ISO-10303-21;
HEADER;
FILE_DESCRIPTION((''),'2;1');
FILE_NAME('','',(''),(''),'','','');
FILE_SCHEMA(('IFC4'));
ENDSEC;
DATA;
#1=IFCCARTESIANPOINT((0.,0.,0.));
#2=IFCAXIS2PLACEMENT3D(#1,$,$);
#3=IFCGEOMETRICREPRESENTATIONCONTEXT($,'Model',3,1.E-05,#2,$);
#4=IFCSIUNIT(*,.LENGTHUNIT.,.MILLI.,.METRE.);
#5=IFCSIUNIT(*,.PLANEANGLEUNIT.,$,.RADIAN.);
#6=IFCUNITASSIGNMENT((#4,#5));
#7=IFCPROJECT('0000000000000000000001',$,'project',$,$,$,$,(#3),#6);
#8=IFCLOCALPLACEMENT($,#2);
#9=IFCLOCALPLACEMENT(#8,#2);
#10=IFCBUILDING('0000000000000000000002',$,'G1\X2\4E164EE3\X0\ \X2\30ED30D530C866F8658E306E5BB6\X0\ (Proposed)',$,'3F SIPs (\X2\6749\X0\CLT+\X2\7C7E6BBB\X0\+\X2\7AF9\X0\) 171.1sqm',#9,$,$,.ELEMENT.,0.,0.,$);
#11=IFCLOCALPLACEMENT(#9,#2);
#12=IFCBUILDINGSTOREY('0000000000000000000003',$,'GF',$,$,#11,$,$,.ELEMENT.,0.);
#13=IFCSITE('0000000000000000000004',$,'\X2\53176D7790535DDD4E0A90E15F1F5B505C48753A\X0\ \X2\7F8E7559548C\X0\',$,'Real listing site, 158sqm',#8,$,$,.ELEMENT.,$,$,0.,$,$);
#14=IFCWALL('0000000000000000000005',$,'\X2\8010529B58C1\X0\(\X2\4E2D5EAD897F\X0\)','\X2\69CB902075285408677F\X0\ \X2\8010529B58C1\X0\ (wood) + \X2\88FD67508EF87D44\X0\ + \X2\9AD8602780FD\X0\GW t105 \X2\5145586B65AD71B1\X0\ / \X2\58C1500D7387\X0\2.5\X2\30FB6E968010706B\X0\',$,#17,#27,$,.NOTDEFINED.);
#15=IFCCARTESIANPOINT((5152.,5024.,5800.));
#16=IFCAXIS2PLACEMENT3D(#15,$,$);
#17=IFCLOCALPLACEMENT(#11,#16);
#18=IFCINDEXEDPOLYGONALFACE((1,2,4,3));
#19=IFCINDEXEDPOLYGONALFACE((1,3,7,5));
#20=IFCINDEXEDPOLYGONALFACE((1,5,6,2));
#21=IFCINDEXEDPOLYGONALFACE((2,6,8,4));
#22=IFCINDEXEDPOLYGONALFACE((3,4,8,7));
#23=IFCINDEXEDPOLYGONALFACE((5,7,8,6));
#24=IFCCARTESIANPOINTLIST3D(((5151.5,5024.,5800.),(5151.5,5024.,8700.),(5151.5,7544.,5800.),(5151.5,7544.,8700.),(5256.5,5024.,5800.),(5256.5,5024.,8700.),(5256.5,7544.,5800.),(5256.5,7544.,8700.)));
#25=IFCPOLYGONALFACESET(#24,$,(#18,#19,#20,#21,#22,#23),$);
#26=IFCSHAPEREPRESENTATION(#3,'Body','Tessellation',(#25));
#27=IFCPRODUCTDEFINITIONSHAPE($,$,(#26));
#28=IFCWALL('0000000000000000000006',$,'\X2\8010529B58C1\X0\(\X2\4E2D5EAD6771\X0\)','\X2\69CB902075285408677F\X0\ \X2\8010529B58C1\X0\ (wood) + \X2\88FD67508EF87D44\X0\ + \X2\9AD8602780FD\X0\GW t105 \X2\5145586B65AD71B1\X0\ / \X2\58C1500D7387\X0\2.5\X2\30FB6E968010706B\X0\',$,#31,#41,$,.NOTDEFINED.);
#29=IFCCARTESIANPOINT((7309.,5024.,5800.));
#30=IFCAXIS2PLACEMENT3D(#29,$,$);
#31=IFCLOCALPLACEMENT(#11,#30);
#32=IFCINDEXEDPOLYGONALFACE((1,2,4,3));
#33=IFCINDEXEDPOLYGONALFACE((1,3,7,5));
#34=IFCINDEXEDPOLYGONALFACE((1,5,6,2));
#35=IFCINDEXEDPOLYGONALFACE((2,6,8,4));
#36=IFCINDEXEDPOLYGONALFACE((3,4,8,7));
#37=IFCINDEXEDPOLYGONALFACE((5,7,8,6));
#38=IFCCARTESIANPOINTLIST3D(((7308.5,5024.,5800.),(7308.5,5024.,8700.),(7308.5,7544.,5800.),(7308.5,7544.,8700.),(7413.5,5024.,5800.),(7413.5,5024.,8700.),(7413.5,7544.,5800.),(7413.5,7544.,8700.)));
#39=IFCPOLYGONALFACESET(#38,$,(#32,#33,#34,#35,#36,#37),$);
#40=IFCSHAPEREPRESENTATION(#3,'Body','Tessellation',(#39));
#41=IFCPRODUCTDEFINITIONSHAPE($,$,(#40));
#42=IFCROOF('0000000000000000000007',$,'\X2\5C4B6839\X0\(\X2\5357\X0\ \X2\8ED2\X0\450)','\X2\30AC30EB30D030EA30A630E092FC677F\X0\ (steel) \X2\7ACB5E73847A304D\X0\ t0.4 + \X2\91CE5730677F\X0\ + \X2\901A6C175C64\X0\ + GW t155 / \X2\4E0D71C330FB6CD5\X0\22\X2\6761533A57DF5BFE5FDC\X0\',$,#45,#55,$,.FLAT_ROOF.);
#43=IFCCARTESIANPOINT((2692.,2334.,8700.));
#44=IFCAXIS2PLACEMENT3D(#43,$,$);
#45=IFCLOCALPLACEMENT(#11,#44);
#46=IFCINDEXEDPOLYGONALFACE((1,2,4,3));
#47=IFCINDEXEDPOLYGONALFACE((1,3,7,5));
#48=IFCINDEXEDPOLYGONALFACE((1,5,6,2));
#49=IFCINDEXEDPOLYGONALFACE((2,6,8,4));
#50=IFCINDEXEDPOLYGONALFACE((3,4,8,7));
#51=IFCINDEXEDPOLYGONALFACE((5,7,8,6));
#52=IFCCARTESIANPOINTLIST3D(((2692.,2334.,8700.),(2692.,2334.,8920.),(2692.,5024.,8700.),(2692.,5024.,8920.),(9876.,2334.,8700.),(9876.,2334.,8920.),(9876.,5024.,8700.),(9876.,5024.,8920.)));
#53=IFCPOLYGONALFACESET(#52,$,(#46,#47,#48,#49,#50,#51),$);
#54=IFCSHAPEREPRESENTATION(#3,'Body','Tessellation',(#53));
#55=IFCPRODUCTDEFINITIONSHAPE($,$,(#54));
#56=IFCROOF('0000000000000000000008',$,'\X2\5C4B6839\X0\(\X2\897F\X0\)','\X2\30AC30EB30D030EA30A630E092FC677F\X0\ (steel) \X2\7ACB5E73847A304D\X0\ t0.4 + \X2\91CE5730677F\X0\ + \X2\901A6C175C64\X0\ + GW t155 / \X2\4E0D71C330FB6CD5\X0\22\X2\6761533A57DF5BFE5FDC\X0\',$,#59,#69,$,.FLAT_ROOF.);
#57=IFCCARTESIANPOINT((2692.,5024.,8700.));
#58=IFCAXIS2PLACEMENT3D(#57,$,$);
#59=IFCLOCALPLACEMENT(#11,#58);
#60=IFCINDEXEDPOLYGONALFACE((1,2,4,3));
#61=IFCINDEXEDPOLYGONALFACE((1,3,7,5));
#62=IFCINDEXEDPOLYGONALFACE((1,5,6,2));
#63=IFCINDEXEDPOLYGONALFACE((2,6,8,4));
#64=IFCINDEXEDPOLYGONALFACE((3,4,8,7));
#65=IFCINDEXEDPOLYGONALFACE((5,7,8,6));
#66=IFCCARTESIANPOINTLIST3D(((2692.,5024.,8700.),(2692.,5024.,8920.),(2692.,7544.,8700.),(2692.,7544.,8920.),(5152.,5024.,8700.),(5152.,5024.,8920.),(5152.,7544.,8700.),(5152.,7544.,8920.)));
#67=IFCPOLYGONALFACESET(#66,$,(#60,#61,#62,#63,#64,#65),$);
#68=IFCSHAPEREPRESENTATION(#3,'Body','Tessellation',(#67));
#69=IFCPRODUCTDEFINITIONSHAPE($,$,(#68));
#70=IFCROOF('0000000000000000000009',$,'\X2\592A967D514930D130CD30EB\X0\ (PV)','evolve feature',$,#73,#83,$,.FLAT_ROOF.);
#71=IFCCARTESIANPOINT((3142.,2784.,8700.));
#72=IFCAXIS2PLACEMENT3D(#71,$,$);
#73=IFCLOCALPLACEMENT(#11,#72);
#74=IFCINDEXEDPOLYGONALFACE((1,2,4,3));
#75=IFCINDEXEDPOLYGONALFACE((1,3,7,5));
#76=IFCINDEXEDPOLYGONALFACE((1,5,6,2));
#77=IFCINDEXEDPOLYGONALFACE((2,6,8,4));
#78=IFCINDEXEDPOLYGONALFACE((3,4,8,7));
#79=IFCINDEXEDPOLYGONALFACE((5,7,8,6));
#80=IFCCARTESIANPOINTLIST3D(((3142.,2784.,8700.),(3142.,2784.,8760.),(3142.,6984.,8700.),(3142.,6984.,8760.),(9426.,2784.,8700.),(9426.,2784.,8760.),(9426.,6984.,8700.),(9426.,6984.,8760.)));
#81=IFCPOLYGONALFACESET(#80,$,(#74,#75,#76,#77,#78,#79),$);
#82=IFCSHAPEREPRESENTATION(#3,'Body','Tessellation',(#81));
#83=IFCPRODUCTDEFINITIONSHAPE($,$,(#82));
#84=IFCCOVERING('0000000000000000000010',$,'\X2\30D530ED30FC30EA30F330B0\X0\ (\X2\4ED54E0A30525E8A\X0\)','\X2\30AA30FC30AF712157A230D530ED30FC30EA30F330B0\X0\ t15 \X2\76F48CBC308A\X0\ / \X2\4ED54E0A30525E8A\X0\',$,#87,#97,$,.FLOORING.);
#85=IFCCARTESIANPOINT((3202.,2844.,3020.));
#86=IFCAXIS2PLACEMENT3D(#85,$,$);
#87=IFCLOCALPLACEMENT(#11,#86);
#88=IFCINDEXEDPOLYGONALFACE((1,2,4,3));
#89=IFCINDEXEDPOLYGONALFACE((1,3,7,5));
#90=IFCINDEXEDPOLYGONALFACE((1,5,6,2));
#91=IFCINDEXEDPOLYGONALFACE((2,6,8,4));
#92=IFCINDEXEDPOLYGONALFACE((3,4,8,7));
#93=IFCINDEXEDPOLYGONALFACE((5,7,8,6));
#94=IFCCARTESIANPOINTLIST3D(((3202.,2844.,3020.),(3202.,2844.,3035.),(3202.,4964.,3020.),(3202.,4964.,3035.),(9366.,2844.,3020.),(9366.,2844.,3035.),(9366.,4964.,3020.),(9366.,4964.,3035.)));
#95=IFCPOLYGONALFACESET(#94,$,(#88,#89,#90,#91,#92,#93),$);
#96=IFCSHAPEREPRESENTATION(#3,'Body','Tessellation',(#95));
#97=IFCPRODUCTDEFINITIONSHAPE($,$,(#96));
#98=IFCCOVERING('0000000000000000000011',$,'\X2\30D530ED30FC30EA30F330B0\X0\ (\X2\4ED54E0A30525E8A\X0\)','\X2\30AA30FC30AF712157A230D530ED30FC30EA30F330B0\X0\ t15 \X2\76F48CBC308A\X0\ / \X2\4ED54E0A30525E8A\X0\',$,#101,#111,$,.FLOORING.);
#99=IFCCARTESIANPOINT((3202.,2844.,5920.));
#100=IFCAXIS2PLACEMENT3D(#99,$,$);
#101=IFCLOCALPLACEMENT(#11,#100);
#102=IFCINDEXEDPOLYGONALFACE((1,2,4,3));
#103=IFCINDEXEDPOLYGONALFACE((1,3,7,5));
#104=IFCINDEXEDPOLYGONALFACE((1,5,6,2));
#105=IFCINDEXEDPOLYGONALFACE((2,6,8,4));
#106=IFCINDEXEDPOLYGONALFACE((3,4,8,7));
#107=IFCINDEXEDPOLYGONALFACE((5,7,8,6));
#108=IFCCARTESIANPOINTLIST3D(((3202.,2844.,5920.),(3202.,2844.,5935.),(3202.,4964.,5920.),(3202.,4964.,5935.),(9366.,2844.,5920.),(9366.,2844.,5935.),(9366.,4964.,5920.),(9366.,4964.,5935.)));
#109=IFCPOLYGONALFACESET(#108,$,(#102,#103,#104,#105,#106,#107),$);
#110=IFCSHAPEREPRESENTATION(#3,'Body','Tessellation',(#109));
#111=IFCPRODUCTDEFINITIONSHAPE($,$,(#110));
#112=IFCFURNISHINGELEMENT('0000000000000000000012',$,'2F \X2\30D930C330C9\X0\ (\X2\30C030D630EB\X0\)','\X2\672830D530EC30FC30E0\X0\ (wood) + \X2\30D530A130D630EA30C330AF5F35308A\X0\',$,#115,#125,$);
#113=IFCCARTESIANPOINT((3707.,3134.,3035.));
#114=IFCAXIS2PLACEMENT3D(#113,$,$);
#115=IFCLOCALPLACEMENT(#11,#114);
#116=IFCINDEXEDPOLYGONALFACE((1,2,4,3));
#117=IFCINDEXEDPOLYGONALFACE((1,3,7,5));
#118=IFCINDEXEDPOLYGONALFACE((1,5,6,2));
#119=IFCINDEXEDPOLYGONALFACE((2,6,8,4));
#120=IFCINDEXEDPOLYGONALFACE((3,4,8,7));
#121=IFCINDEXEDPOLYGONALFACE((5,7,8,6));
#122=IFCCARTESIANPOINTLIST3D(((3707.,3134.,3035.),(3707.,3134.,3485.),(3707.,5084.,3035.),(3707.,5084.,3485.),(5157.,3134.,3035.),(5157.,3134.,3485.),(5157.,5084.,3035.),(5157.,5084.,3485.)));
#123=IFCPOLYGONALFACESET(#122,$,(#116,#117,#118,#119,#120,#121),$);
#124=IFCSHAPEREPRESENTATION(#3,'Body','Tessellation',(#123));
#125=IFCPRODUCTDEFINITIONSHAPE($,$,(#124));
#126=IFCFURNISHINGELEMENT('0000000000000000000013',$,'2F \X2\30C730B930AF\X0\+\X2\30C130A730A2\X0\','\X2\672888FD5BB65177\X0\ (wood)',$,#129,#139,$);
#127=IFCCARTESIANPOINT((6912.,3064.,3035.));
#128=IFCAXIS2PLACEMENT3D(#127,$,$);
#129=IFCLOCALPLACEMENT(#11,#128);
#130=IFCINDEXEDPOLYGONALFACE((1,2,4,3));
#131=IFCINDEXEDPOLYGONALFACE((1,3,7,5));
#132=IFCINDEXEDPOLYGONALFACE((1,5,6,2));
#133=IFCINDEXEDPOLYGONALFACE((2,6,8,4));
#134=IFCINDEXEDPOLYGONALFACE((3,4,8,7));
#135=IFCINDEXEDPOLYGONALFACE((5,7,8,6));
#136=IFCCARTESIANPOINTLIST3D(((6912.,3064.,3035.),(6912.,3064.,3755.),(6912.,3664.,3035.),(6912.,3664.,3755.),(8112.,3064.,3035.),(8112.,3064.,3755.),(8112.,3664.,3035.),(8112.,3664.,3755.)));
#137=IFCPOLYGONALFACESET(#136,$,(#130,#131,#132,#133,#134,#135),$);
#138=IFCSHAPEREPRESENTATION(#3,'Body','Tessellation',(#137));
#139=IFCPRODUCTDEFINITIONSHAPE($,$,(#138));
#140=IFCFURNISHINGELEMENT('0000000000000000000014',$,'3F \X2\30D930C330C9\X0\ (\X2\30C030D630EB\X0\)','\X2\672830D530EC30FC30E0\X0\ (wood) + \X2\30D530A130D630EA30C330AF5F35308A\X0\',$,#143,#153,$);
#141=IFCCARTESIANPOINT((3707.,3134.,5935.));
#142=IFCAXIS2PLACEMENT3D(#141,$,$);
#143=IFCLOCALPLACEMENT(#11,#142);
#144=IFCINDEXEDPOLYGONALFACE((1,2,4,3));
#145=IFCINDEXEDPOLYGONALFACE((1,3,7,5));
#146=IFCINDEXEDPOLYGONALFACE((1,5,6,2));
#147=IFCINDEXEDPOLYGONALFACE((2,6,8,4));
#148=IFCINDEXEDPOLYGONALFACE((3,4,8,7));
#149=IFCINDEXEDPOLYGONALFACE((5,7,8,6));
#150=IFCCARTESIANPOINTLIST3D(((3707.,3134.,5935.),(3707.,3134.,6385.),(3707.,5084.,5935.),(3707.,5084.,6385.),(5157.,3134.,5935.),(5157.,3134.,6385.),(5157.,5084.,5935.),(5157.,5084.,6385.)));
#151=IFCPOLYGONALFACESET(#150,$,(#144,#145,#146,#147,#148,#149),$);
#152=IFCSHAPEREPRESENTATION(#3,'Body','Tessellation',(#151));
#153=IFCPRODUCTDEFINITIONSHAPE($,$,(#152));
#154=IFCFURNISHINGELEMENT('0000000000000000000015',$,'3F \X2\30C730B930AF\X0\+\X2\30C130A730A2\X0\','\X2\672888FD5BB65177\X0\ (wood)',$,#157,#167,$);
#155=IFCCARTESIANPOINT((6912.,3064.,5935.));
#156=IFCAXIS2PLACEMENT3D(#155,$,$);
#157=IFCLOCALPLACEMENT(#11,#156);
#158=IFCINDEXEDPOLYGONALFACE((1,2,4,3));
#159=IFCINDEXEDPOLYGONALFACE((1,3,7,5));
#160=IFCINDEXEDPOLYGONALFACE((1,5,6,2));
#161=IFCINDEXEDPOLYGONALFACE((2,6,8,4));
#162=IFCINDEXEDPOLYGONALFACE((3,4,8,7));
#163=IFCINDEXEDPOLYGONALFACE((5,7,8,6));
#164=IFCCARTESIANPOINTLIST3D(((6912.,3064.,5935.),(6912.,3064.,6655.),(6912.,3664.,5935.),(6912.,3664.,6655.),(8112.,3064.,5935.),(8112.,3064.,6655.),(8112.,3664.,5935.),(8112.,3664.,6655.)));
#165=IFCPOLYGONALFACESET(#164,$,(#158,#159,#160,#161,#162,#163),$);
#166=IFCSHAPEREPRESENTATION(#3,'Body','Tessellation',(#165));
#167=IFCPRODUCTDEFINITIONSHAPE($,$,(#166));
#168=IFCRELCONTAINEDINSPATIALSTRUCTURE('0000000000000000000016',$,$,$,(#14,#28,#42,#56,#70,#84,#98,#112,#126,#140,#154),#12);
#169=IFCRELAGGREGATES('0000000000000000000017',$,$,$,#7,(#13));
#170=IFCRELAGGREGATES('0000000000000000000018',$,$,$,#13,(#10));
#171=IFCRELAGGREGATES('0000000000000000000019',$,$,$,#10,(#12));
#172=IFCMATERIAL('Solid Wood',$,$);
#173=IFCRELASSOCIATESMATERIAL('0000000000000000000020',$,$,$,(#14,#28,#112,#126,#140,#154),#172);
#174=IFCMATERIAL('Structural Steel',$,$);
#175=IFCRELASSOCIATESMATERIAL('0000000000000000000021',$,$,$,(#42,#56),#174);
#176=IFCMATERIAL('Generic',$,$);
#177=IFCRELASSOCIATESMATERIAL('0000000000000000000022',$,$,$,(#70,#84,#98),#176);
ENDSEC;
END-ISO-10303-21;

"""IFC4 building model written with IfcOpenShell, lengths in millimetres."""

from ifc_helpers import new_model, si_unit, frame, frame_2d, origin, place, context, project, spatial, rectangle, extrude, material, element, save


model = new_model("IFC4")

# Units and contexts
model_context = context("Model", 3, precision=1e-05, world=origin())
ifc_project = project(units=[si_unit("LENGTHUNIT", "METRE", prefix="MILLI"), si_unit("PLANEANGLEUNIT", "RADIAN")], contexts=[model_context])

# Site, building, storey
site_placement = place(None, origin())
site = spatial("IfcSite", under=ifc_project, at=site_placement, Name="北海道川上郡弟子屈町 美留和", ObjectType="Real listing site, 158sqm", CompositionType="ELEMENT", RefElevation=0.0)
building_placement = place(site_placement, origin())
building = spatial("IfcBuilding", under=site, at=building_placement, Name="G1世代 ロフト書斎の家 (Proposed)", ObjectType="3F SIPs (杉CLT+籾殻+竹) 171.1sqm", CompositionType="ELEMENT", ElevationOfRefHeight=0.0, ElevationOfTerrain=0.0)
storey_placement = place(building_placement, origin())
storey = spatial("IfcBuildingStorey", under=building, at=storey_placement, Name="GF", CompositionType="ELEMENT", Elevation=0.0)

# Shared definitions
ifc_material_1 = material(Name="Solid Wood")

# Walls
wall_1_placement = place(storey_placement, frame((5152.0, 5024.0, 5800.0)))
element("IfcWall", 1, at=wall_1_placement, inside=storey, material=ifc_material_1, Name="耐力壁(中庭西)", Description="構造用合板 耐力壁 (wood) + 製材軸組 + 高性能GW t105 充填断熱 / 壁倍率2.5・準耐火", PredefinedType="NOTDEFINED", context=model_context, shape_type="SweptSolid", body=[
    extrude(rectangle(XDim=105.0, YDim=2520.0, at=frame_2d((52.0, 1260.0))), frame((5152.0, 5024.0, 5800.0)), (0.0, 0.0, 1.0), 2900.0),
])
wall_2_placement = place(storey_placement, frame((7309.0, 5024.0, 5800.0)))
element("IfcWall", 2, at=wall_2_placement, inside=storey, material=ifc_material_1, Name="耐力壁(中庭東)", Description="構造用合板 耐力壁 (wood) + 製材軸組 + 高性能GW t105 充填断熱 / 壁倍率2.5・準耐火", PredefinedType="NOTDEFINED", context=model_context, shape_type="SweptSolid", body=[
    extrude(rectangle(XDim=105.0, YDim=2520.0, at=frame_2d((52.0, 1260.0))), frame((7309.0, 5024.0, 5800.0)), (0.0, 0.0, 1.0), 2900.0),
])

# Roofs
ifc_material_2 = material(Name="Structural Steel")
roof_1_placement = place(storey_placement, frame((2692.0, 2334.0, 8700.0)))
element("IfcRoof", 3, at=roof_1_placement, inside=storey, material=ifc_material_2, Name="屋根(南 軒450)", Description="ガルバリウム鋼板 (steel) 立平葺き t0.4 + 野地板 + 通気層 + GW t155 / 不燃・法22条区域対応", PredefinedType="FLAT_ROOF", context=model_context, shape_type="SweptSolid", body=[
    extrude(rectangle(XDim=7184.0, YDim=2690.0, at=frame_2d((3592.0, 1345.0))), frame((2692.0, 2334.0, 8700.0)), (0.0, 0.0, 1.0), 220.0),
])
roof_2_placement = place(storey_placement, frame((2692.0, 5024.0, 8700.0)))
element("IfcRoof", 4, at=roof_2_placement, inside=storey, material=ifc_material_2, Name="屋根(西)", Description="ガルバリウム鋼板 (steel) 立平葺き t0.4 + 野地板 + 通気層 + GW t155 / 不燃・法22条区域対応", PredefinedType="FLAT_ROOF", context=model_context, shape_type="SweptSolid", body=[
    extrude(rectangle(XDim=2460.0, YDim=2520.0, at=frame_2d((1230.0, 1260.0))), frame((2692.0, 5024.0, 8700.0)), (0.0, 0.0, 1.0), 220.0),
])
ifc_material_3 = material(Name="Generic")
roof_3_placement = place(storey_placement, frame((3142.0, 2784.0, 8700.0)))
element("IfcRoof", 5, at=roof_3_placement, inside=storey, material=ifc_material_3, Name="太陽光パネル (PV)", Description="evolve feature", PredefinedType="FLAT_ROOF", context=model_context, shape_type="SweptSolid", body=[
    extrude(rectangle(XDim=6284.0, YDim=4200.0, at=frame_2d((3142.0, 2100.0))), frame((3142.0, 2784.0, 8700.0)), (0.0, 0.0, 1.0), 60.0),
])

# Coverings
covering_1_placement = place(storey_placement, frame((3202.0, 2844.0, 3020.0)))
element("IfcCovering", 6, at=covering_1_placement, inside=storey, material=ifc_material_3, Name="フローリング (仕上げ床)", Description="オーク無垢フローリング t15 直貼り / 仕上げ床", PredefinedType="FLOORING", context=model_context, shape_type="SweptSolid", body=[
    extrude(rectangle(XDim=6164.0, YDim=2120.0, at=frame_2d((3082.0, 1060.0))), frame((3202.0, 2844.0, 3020.0)), (0.0, 0.0, 1.0), 15.0),
])
covering_2_placement = place(storey_placement, frame((3202.0, 2844.0, 5920.0)))
element("IfcCovering", 7, at=covering_2_placement, inside=storey, material=ifc_material_3, Name="フローリング (仕上げ床)", Description="オーク無垢フローリング t15 直貼り / 仕上げ床", PredefinedType="FLOORING", context=model_context, shape_type="SweptSolid", body=[
    extrude(rectangle(XDim=6164.0, YDim=2120.0, at=frame_2d((3082.0, 1060.0))), frame((3202.0, 2844.0, 5920.0)), (0.0, 0.0, 1.0), 15.0),
])

# Furnishing elements
furnishing_1_placement = place(storey_placement, frame((3707.0, 3134.0, 3035.0)))
element("IfcFurnishingElement", 8, at=furnishing_1_placement, inside=storey, material=ifc_material_1, Name="2F ベッド (ダブル)", Description="木フレーム (wood) + ファブリック張り", context=model_context, shape_type="SweptSolid", body=[
    extrude(rectangle(XDim=1450.0, YDim=1950.0, at=frame_2d((725.0, 975.0))), frame((3707.0, 3134.0, 3035.0)), (0.0, 0.0, 1.0), 450.0),
])
furnishing_2_placement = place(storey_placement, frame((6912.0, 3064.0, 3035.0)))
element("IfcFurnishingElement", 9, at=furnishing_2_placement, inside=storey, material=ifc_material_1, Name="2F デスク+チェア", Description="木製家具 (wood)", context=model_context, shape_type="SweptSolid", body=[
    extrude(rectangle(XDim=1200.0, YDim=600.0, at=frame_2d((600.0, 300.0))), frame((6912.0, 3064.0, 3035.0)), (0.0, 0.0, 1.0), 720.0),
])
furnishing_3_placement = place(storey_placement, frame((3707.0, 3134.0, 5935.0)))
element("IfcFurnishingElement", 10, at=furnishing_3_placement, inside=storey, material=ifc_material_1, Name="3F ベッド (ダブル)", Description="木フレーム (wood) + ファブリック張り", context=model_context, shape_type="SweptSolid", body=[
    extrude(rectangle(XDim=1450.0, YDim=1950.0, at=frame_2d((725.0, 975.0))), frame((3707.0, 3134.0, 5935.0)), (0.0, 0.0, 1.0), 450.0),
])
furnishing_4_placement = place(storey_placement, frame((6912.0, 3064.0, 5935.0)))
element("IfcFurnishingElement", 11, at=furnishing_4_placement, inside=storey, material=ifc_material_1, Name="3F デスク+チェア", Description="木製家具 (wood)", context=model_context, shape_type="SweptSolid", body=[
    extrude(rectangle(XDim=1200.0, YDim=600.0, at=frame_2d((600.0, 300.0))), frame((6912.0, 3064.0, 5935.0)), (0.0, 0.0, 1.0), 720.0),
])

save(model, "model.ifc")
